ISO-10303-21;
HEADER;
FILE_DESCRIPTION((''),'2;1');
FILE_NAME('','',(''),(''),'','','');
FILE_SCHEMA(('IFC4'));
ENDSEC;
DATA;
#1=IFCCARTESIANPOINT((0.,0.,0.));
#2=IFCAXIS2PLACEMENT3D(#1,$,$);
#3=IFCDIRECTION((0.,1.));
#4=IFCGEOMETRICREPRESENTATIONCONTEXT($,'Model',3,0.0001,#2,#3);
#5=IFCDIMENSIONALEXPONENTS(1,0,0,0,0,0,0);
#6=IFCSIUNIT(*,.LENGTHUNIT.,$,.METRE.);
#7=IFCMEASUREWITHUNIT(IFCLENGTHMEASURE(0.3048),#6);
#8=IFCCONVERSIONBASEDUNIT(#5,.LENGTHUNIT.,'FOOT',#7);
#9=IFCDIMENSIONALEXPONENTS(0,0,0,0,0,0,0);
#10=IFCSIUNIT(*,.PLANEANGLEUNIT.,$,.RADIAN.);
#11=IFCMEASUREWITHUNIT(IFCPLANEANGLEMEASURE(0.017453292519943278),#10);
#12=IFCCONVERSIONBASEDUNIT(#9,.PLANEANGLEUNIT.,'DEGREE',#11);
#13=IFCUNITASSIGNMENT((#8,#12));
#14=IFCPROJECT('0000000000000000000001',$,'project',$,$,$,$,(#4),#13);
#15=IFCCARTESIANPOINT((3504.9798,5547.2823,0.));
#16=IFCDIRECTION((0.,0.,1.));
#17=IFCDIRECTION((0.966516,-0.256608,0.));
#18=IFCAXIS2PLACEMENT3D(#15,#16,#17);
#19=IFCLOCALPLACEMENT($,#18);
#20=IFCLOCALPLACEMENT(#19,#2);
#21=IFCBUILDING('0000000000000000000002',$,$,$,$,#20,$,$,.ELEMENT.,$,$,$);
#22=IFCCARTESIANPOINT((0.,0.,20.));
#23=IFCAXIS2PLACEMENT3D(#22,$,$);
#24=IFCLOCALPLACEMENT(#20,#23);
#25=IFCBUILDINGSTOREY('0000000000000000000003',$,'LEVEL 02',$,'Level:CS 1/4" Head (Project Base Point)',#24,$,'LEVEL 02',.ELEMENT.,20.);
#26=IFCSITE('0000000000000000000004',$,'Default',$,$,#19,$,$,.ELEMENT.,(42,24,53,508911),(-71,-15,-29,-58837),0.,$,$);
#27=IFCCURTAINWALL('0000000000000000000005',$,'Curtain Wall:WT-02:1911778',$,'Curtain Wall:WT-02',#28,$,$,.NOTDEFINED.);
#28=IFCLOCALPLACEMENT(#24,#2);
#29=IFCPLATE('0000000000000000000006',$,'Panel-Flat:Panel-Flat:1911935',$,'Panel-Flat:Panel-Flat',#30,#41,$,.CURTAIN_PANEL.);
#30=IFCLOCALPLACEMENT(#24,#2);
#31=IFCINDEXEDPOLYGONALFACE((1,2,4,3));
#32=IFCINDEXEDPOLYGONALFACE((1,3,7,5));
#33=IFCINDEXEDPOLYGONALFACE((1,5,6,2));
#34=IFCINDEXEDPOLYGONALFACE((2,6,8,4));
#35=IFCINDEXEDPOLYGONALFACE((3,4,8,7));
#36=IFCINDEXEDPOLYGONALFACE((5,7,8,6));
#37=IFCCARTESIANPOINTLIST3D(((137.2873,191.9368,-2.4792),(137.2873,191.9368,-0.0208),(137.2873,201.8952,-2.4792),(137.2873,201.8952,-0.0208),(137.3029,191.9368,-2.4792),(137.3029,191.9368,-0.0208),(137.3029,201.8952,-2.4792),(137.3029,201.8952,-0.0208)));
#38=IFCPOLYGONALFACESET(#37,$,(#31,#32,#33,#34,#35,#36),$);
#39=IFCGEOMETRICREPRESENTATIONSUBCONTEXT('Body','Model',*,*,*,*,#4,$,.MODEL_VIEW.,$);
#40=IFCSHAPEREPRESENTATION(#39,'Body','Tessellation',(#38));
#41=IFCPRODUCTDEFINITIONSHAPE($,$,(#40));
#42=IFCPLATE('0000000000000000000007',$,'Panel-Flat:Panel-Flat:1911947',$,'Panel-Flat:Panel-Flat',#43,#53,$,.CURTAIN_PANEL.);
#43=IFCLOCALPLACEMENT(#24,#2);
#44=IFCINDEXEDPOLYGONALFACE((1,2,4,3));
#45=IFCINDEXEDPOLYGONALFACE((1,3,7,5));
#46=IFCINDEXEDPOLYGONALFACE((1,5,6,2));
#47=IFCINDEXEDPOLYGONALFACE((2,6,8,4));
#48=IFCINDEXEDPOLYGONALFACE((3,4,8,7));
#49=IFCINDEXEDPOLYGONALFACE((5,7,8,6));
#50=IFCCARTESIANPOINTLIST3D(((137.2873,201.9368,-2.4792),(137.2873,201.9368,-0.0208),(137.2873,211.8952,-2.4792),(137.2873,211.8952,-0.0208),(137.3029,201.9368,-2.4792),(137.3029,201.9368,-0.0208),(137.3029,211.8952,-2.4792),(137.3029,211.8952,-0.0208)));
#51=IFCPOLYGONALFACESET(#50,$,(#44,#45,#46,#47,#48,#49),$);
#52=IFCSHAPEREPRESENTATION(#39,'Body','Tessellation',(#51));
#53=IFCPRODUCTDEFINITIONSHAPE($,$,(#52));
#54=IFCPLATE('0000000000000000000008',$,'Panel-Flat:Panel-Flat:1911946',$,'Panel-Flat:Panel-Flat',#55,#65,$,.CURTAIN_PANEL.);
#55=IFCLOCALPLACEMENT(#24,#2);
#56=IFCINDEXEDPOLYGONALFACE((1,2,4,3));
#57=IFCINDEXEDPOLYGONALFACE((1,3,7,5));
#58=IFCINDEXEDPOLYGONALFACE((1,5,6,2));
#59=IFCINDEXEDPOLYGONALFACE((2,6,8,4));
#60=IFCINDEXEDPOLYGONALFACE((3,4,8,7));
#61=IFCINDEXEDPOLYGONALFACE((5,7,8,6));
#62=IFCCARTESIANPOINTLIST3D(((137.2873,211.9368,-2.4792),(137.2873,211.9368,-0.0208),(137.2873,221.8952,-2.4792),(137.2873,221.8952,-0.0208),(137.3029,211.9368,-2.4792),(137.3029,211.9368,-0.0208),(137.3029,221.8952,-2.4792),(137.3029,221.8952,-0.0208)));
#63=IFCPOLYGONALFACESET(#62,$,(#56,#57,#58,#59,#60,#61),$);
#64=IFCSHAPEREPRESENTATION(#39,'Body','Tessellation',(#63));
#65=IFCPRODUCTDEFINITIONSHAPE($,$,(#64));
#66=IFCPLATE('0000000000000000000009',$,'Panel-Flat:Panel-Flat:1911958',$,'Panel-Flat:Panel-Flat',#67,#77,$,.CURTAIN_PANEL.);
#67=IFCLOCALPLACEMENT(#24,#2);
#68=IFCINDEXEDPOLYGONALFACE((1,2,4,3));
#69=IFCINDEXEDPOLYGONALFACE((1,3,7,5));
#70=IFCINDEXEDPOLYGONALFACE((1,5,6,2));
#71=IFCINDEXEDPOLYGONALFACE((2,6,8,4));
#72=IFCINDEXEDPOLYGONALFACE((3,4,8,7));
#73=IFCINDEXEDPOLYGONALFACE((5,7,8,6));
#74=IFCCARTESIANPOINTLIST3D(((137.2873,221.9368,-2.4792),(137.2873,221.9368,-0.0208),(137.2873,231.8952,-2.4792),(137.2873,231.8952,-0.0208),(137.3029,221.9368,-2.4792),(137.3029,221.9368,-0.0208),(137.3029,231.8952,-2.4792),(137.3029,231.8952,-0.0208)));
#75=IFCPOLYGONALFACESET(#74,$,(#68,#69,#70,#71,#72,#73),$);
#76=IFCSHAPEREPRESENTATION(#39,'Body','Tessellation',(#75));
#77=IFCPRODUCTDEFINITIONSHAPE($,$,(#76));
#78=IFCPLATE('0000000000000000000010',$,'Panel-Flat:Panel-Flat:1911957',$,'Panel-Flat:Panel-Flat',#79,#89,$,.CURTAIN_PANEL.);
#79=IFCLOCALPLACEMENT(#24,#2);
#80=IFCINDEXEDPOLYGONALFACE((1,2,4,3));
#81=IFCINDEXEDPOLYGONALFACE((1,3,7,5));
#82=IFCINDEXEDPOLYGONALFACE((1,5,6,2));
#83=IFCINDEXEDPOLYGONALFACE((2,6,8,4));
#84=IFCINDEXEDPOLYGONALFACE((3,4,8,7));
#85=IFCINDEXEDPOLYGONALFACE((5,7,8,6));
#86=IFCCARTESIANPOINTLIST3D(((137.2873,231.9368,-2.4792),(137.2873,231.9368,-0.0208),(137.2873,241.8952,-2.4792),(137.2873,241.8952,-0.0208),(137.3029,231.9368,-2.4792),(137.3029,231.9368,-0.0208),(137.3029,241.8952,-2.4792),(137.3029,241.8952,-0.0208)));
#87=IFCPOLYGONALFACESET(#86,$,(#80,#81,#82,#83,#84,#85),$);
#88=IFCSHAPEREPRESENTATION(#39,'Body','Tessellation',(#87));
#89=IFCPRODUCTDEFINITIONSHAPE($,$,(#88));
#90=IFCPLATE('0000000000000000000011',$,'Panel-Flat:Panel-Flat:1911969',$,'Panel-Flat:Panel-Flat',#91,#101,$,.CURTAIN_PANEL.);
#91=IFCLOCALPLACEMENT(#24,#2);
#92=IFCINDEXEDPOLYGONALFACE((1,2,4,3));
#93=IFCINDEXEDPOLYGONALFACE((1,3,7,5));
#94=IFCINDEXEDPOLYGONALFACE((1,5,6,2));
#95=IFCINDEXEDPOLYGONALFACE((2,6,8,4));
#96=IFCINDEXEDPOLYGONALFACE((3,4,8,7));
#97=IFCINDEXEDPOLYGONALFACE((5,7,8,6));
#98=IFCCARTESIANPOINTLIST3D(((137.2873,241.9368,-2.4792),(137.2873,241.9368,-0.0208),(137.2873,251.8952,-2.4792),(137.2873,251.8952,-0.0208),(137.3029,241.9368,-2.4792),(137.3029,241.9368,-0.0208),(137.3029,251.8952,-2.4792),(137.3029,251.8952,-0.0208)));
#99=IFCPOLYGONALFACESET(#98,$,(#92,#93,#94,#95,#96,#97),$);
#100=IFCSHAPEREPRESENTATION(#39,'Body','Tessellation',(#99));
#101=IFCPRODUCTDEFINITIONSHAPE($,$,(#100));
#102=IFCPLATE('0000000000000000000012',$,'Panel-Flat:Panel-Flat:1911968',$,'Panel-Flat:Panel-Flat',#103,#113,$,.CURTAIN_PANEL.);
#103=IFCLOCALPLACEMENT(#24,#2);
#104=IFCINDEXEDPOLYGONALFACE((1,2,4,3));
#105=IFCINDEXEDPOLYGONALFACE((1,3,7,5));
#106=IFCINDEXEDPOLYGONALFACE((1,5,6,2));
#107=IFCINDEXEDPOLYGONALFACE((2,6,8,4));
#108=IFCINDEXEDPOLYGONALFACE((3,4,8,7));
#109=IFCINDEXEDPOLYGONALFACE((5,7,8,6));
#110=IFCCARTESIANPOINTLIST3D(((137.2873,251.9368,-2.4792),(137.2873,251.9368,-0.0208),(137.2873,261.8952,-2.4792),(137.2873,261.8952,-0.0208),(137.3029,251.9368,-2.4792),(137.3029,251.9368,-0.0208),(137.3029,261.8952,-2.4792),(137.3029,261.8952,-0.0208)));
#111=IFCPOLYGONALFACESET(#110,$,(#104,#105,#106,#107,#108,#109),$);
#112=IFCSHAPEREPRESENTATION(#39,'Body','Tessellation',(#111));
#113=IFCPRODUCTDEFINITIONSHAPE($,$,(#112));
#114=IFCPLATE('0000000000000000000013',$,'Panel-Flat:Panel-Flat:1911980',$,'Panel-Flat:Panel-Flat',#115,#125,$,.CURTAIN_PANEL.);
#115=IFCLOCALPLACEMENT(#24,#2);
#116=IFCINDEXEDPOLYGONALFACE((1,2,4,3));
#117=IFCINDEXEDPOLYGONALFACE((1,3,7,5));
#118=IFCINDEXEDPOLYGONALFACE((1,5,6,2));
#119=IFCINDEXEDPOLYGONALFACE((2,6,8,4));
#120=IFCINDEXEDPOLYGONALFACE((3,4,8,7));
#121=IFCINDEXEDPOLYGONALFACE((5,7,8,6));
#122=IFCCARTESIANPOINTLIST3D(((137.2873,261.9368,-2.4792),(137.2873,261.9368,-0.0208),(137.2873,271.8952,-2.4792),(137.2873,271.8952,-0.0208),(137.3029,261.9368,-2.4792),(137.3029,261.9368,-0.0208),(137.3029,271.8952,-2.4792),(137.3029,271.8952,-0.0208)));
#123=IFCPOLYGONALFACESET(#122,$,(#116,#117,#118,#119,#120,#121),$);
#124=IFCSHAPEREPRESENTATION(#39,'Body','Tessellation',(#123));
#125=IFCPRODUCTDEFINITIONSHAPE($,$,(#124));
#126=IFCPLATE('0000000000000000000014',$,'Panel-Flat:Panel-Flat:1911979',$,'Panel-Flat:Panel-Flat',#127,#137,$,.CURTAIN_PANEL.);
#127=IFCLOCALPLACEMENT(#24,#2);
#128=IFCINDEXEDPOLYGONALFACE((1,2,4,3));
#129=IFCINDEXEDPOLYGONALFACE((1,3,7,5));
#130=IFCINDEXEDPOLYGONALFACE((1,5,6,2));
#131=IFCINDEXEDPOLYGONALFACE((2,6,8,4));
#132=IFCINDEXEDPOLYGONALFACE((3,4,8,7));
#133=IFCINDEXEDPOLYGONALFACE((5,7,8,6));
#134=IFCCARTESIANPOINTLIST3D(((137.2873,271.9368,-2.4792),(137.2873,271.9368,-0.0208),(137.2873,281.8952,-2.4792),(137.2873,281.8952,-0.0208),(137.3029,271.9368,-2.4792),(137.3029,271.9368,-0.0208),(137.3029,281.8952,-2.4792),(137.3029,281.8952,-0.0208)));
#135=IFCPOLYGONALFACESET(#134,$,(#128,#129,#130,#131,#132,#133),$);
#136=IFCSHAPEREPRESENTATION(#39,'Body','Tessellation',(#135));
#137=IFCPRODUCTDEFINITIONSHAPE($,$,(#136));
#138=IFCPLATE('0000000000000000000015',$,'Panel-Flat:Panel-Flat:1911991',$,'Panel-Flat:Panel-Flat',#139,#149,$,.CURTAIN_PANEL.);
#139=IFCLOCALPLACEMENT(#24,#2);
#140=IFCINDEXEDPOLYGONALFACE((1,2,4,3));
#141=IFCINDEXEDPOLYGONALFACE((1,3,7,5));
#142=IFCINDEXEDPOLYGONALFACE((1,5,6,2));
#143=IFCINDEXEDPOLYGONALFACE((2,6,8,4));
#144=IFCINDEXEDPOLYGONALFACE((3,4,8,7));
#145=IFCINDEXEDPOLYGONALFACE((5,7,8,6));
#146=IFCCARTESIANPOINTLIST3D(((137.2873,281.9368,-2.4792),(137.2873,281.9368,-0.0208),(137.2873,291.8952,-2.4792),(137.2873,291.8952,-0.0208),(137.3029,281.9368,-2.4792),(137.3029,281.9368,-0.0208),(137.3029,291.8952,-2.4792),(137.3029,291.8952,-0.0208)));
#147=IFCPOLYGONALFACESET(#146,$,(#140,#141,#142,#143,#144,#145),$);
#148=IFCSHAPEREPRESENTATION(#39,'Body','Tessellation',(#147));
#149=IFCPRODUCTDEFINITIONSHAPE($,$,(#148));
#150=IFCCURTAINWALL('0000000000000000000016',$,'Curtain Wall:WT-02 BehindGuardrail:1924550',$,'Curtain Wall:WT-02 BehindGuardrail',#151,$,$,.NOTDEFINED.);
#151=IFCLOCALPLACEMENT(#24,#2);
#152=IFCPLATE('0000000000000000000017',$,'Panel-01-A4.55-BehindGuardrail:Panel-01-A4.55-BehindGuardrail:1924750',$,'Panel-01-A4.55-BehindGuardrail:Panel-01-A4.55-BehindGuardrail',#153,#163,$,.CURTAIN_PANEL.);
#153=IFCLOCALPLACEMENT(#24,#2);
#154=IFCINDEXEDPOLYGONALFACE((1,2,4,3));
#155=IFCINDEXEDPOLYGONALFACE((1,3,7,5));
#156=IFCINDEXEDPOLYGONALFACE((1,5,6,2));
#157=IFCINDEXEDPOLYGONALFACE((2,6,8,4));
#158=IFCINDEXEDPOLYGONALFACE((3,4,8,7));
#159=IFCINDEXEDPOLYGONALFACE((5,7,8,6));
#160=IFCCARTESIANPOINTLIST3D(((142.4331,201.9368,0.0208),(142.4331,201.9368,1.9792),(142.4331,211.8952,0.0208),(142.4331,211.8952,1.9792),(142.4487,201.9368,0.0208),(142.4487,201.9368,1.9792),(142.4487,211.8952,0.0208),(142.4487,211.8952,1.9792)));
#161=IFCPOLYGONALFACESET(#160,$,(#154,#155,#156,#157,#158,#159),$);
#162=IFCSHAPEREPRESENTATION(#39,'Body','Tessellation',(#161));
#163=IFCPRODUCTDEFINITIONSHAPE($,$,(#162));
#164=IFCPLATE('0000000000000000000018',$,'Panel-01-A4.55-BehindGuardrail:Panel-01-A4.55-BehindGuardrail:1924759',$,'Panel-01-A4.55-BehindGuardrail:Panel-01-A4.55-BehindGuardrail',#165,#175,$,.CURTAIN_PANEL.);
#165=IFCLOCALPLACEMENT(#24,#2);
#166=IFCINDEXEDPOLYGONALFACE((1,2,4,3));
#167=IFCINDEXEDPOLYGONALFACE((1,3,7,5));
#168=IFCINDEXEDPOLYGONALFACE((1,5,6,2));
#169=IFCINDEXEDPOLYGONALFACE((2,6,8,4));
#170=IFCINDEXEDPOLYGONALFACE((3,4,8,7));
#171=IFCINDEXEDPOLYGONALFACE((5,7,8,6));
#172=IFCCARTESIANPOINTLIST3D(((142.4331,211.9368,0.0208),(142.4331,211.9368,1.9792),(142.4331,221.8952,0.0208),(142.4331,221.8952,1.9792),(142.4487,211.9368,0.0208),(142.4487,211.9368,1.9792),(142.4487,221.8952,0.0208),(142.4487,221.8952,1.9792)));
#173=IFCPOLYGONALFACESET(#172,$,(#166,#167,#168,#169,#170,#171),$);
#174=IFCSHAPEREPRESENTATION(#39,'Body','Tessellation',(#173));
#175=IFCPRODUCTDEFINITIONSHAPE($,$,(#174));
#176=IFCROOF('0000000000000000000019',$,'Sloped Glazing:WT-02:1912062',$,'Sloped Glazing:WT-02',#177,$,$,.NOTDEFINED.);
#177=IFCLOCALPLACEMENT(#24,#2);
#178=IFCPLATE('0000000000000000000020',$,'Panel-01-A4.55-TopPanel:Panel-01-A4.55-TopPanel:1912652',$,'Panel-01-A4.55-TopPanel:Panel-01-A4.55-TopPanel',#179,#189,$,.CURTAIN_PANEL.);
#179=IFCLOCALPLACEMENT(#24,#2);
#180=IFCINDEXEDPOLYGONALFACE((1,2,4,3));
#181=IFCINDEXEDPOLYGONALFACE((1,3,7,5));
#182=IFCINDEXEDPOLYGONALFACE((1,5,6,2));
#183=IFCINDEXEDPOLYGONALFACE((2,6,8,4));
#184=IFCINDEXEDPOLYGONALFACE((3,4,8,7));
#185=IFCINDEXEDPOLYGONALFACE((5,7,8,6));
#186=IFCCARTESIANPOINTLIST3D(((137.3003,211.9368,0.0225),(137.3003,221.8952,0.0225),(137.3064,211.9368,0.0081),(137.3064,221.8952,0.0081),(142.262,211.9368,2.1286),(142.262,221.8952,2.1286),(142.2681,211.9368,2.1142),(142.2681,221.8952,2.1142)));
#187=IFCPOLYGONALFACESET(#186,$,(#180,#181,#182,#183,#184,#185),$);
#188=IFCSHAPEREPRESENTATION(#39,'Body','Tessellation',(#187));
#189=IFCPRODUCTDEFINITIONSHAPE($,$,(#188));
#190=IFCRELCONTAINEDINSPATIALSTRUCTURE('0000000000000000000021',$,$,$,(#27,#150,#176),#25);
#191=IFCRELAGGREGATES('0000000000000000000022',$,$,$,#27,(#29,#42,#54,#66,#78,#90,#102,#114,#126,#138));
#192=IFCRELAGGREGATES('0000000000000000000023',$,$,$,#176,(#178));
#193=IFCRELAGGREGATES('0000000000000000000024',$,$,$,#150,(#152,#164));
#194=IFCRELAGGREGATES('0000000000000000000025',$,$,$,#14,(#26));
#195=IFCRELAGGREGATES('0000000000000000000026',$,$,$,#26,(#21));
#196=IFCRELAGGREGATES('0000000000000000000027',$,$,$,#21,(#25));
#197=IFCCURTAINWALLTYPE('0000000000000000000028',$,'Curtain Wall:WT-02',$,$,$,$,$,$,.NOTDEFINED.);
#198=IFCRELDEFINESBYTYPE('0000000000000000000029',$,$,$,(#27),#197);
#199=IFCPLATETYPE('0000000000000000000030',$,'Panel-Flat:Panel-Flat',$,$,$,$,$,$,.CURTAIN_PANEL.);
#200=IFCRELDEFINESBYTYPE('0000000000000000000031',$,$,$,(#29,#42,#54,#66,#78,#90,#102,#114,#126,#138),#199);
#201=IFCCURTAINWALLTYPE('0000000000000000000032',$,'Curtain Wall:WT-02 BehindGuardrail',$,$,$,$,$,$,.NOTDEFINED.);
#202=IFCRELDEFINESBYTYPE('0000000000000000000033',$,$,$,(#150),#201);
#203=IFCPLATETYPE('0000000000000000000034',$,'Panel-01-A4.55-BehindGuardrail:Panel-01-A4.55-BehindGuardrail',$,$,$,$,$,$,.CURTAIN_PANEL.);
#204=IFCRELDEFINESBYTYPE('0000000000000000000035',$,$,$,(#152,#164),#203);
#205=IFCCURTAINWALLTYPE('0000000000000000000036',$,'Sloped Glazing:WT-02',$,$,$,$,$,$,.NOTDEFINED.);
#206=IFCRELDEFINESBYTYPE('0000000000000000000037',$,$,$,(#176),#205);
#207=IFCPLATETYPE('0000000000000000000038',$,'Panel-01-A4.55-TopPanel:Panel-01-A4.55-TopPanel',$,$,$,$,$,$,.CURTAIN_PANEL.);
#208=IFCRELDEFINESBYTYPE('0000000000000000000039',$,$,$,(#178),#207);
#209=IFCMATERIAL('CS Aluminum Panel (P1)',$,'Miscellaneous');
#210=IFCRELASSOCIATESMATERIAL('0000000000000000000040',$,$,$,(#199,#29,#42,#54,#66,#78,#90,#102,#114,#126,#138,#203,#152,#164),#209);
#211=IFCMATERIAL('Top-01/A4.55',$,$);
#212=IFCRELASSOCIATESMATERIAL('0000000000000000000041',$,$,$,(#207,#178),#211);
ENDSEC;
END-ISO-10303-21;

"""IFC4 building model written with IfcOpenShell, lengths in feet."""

from ifc_helpers import new_model, entity, si_unit, converted_unit, direction, frame, origin, place, context, subcontext, project, spatial, indexed_curve, outline, extrude, source, transform, mapped, material, type_object, type_shapes, element, aggregate, save


model = new_model("IFC4")

# Units and contexts
model_context = context("Model", 3, precision=0.0001, world=origin(), true_north=direction((0.0, 1.0)))
body_context = subcontext(model_context, "Body", "Model", "MODEL_VIEW")
ifc_project = project(units=[converted_unit("LENGTHUNIT", "FOOT", entity("IfcLengthMeasure", 0.3048), si_unit("LENGTHUNIT", "METRE"), dimensions=[1, 0, 0, 0, 0, 0, 0]), converted_unit("PLANEANGLEUNIT", "DEGREE", entity("IfcPlaneAngleMeasure", 0.017453292519943278), si_unit("PLANEANGLEUNIT", "RADIAN"), dimensions=[0, 0, 0, 0, 0, 0, 0])], contexts=[model_context])

# Site, building, storey
site_placement = place(None, frame((3504.9798, 5547.2823, 0.0), z_axis=(0.0, 0.0, 1.0), x_axis=(0.966516, -0.256608, 0.0)))
site = spatial("IfcSite", under=ifc_project, at=site_placement, Name="Default", CompositionType="ELEMENT", RefLatitude=(42, 24, 53, 508911), RefLongitude=(-71, -15, -29, -58837), RefElevation=0.0)
building_placement = place(site_placement, origin())
building = spatial("IfcBuilding", under=site, at=building_placement, CompositionType="ELEMENT")
storey_placement = place(building_placement, frame((0.0, 0.0, 20.0)))
storey = spatial("IfcBuildingStorey", under=building, at=storey_placement, Name="LEVEL 02", ObjectType="Level:CS 1/4\" Head (Project Base Point)", LongName="LEVEL 02", CompositionType="ELEMENT", Elevation=20.0)

# Curtain walls, plates
curtain_wall_type_1 = type_object("IfcCurtainWallType", Name="Curtain Wall:WT-02", PredefinedType="NOTDEFINED")
curtain_wall_1_placement = place(storey_placement, frame((0.0, 0.0, -20.0)))
curtain_wall_1 = element("IfcCurtainWall", 1, at=curtain_wall_1_placement, inside=storey, type_object=curtain_wall_type_1, Name="Curtain Wall:WT-02:1911778", ObjectType="Curtain Wall:WT-02", PredefinedType="NOTDEFINED")
ifc_material_1 = material(Name="CS Aluminum Panel (P1)", Category="Miscellaneous")
plate_type_1 = type_object("IfcPlateType", Name="Panel-Flat:Panel-Flat", PredefinedType="CURTAIN_PANEL", material=ifc_material_1)
shared_shape_1 = source(origin(), body_context, "Body", "SweptSolid", [
    extrude(outline(indexed_curve([(-0.0078, -4.9792), (0.0078, -4.9792), (0.0078, 4.9792), (-0.0078, 4.9792), (-0.0078, -4.9792)], self_intersect=False)), frame((4.9792, 0.0078, 0.0), z_axis=(0.0, 0.0, 1.0), x_axis=(0.0, -1.0, 0.0)), (0.0, 0.0, 1.0), 2.4583),
])
type_shapes(plate_type_1, [shared_shape_1])
plate_1_placement = place(curtain_wall_1_placement, frame((137.3029, 191.9368, 17.5208), z_axis=(0.0, 0.0, 1.0), x_axis=(0.0, 1.0, 0.0)))
plate_1 = element("IfcPlate", 2, at=plate_1_placement, type_object=plate_type_1, material=ifc_material_1, Name="Panel-Flat:Panel-Flat:1911935", ObjectType="Panel-Flat:Panel-Flat", PredefinedType="CURTAIN_PANEL", context=body_context, shape_type="MappedRepresentation", body=[
    mapped(shared_shape_1, transform((0.0, 0.0, 0.0), scale=1.0)),
])
plate_2_placement = place(curtain_wall_1_placement, frame((137.3029, 201.9368, 17.5208), z_axis=(0.0, 0.0, 1.0), x_axis=(0.0, 1.0, 0.0)))
plate_2 = element("IfcPlate", 3, at=plate_2_placement, type_object=plate_type_1, material=ifc_material_1, Name="Panel-Flat:Panel-Flat:1911947", ObjectType="Panel-Flat:Panel-Flat", PredefinedType="CURTAIN_PANEL", context=body_context, shape_type="MappedRepresentation", body=[
    mapped(shared_shape_1, transform((0.0, 0.0, 0.0), scale=1.0)),
])
plate_3_placement = place(curtain_wall_1_placement, frame((137.3029, 211.9368, 17.5208), z_axis=(0.0, 0.0, 1.0), x_axis=(0.0, 1.0, 0.0)))
plate_3 = element("IfcPlate", 4, at=plate_3_placement, type_object=plate_type_1, material=ifc_material_1, Name="Panel-Flat:Panel-Flat:1911946", ObjectType="Panel-Flat:Panel-Flat", PredefinedType="CURTAIN_PANEL", context=body_context, shape_type="MappedRepresentation", body=[
    mapped(shared_shape_1, transform((0.0, 0.0, 0.0), scale=1.0)),
])
plate_4_placement = place(curtain_wall_1_placement, frame((137.3029, 221.9368, 17.5208), z_axis=(0.0, 0.0, 1.0), x_axis=(0.0, 1.0, 0.0)))
plate_4 = element("IfcPlate", 5, at=plate_4_placement, type_object=plate_type_1, material=ifc_material_1, Name="Panel-Flat:Panel-Flat:1911958", ObjectType="Panel-Flat:Panel-Flat", PredefinedType="CURTAIN_PANEL", context=body_context, shape_type="MappedRepresentation", body=[
    mapped(shared_shape_1, transform((0.0, 0.0, 0.0), scale=1.0)),
])
plate_5_placement = place(curtain_wall_1_placement, frame((137.3029, 231.9368, 17.5208), z_axis=(0.0, 0.0, 1.0), x_axis=(0.0, 1.0, 0.0)))
plate_5 = element("IfcPlate", 6, at=plate_5_placement, type_object=plate_type_1, material=ifc_material_1, Name="Panel-Flat:Panel-Flat:1911957", ObjectType="Panel-Flat:Panel-Flat", PredefinedType="CURTAIN_PANEL", context=body_context, shape_type="MappedRepresentation", body=[
    mapped(shared_shape_1, transform((0.0, 0.0, 0.0), scale=1.0)),
])
plate_6_placement = place(curtain_wall_1_placement, frame((137.3029, 241.9368, 17.5208), z_axis=(0.0, 0.0, 1.0), x_axis=(0.0, 1.0, 0.0)))
plate_6 = element("IfcPlate", 7, at=plate_6_placement, type_object=plate_type_1, material=ifc_material_1, Name="Panel-Flat:Panel-Flat:1911969", ObjectType="Panel-Flat:Panel-Flat", PredefinedType="CURTAIN_PANEL", context=body_context, shape_type="MappedRepresentation", body=[
    mapped(shared_shape_1, transform((0.0, 0.0, 0.0), scale=1.0)),
])
plate_7_placement = place(curtain_wall_1_placement, frame((137.3029, 251.9368, 17.5208), z_axis=(0.0, 0.0, 1.0), x_axis=(0.0, 1.0, 0.0)))
plate_7 = element("IfcPlate", 8, at=plate_7_placement, type_object=plate_type_1, material=ifc_material_1, Name="Panel-Flat:Panel-Flat:1911968", ObjectType="Panel-Flat:Panel-Flat", PredefinedType="CURTAIN_PANEL", context=body_context, shape_type="MappedRepresentation", body=[
    mapped(shared_shape_1, transform((0.0, 0.0, 0.0), scale=1.0)),
])
plate_8_placement = place(curtain_wall_1_placement, frame((137.3029, 261.9368, 17.5208), z_axis=(0.0, 0.0, 1.0), x_axis=(0.0, 1.0, 0.0)))
plate_8 = element("IfcPlate", 9, at=plate_8_placement, type_object=plate_type_1, material=ifc_material_1, Name="Panel-Flat:Panel-Flat:1911980", ObjectType="Panel-Flat:Panel-Flat", PredefinedType="CURTAIN_PANEL", context=body_context, shape_type="MappedRepresentation", body=[
    mapped(shared_shape_1, transform((0.0, 0.0, 0.0), scale=1.0)),
])
plate_9_placement = place(curtain_wall_1_placement, frame((137.3029, 271.9368, 17.5208), z_axis=(0.0, 0.0, 1.0), x_axis=(0.0, 1.0, 0.0)))
plate_9 = element("IfcPlate", 10, at=plate_9_placement, type_object=plate_type_1, material=ifc_material_1, Name="Panel-Flat:Panel-Flat:1911979", ObjectType="Panel-Flat:Panel-Flat", PredefinedType="CURTAIN_PANEL", context=body_context, shape_type="MappedRepresentation", body=[
    mapped(shared_shape_1, transform((0.0, 0.0, 0.0), scale=1.0)),
])
plate_10_placement = place(curtain_wall_1_placement, frame((137.3029, 281.9368, 17.5208), z_axis=(0.0, 0.0, 1.0), x_axis=(0.0, 1.0, 0.0)))
plate_10 = element("IfcPlate", 11, at=plate_10_placement, type_object=plate_type_1, material=ifc_material_1, Name="Panel-Flat:Panel-Flat:1911991", ObjectType="Panel-Flat:Panel-Flat", PredefinedType="CURTAIN_PANEL", context=body_context, shape_type="MappedRepresentation", body=[
    mapped(shared_shape_1, transform((0.0, 0.0, 0.0), scale=1.0)),
])
aggregate(curtain_wall_1, [plate_1, plate_2, plate_3, plate_4, plate_5, plate_6, plate_7, plate_8, plate_9, plate_10])
curtain_wall_type_2 = type_object("IfcCurtainWallType", Name="Curtain Wall:WT-02 BehindGuardrail", PredefinedType="NOTDEFINED")
curtain_wall_2_placement = place(storey_placement, frame((0.0, 0.0, -20.0)))
curtain_wall_2 = element("IfcCurtainWall", 12, at=curtain_wall_2_placement, inside=storey, type_object=curtain_wall_type_2, Name="Curtain Wall:WT-02 BehindGuardrail:1924550", ObjectType="Curtain Wall:WT-02 BehindGuardrail", PredefinedType="NOTDEFINED")
plate_type_2 = type_object("IfcPlateType", Name="Panel-01-A4.55-BehindGuardrail:Panel-01-A4.55-BehindGuardrail", PredefinedType="CURTAIN_PANEL", material=ifc_material_1)
shared_shape_2 = source(origin(), body_context, "Body", "SweptSolid", [
    extrude(outline(indexed_curve([(-0.0078, -4.9792), (0.0078, -4.9792), (0.0078, 4.9792), (-0.0078, 4.9792), (-0.0078, -4.9792)], self_intersect=False)), frame((4.9792, 0.0078, 0.0), z_axis=(0.0, 0.0, 1.0), x_axis=(0.0, -1.0, 0.0)), (0.0, 0.0, 1.0), 1.9583),
])
type_shapes(plate_type_2, [shared_shape_2])
plate_11_placement = place(curtain_wall_2_placement, frame((142.4487, 201.9368, 20.0208), z_axis=(0.0, 0.0, 1.0), x_axis=(0.0, 1.0, 0.0)))
plate_11 = element("IfcPlate", 13, at=plate_11_placement, type_object=plate_type_2, material=ifc_material_1, Name="Panel-01-A4.55-BehindGuardrail:Panel-01-A4.55-BehindGuardrail:1924750", ObjectType="Panel-01-A4.55-BehindGuardrail:Panel-01-A4.55-BehindGuardrail", PredefinedType="CURTAIN_PANEL", context=body_context, shape_type="MappedRepresentation", body=[
    mapped(shared_shape_2, transform((0.0, 0.0, 0.0), scale=1.0)),
])
plate_12_placement = place(curtain_wall_2_placement, frame((142.4487, 211.9368, 20.0208), z_axis=(0.0, 0.0, 1.0), x_axis=(0.0, 1.0, 0.0)))
plate_12 = element("IfcPlate", 14, at=plate_12_placement, type_object=plate_type_2, material=ifc_material_1, Name="Panel-01-A4.55-BehindGuardrail:Panel-01-A4.55-BehindGuardrail:1924759", ObjectType="Panel-01-A4.55-BehindGuardrail:Panel-01-A4.55-BehindGuardrail", PredefinedType="CURTAIN_PANEL", context=body_context, shape_type="MappedRepresentation", body=[
    mapped(shared_shape_2, transform((0.0, 0.0, 0.0), scale=1.0)),
])

# Roof, plate
curtain_wall_type_3 = type_object("IfcCurtainWallType", Name="Sloped Glazing:WT-02", PredefinedType="NOTDEFINED")
roof_1_placement = place(storey_placement, frame((0.0, 0.0, -20.0)))
roof_1 = element("IfcRoof", 15, at=roof_1_placement, inside=storey, type_object=curtain_wall_type_3, Name="Sloped Glazing:WT-02:1912062", ObjectType="Sloped Glazing:WT-02", PredefinedType="NOTDEFINED")
ifc_material_2 = material(Name="Top-01/A4.55")
plate_type_3 = type_object("IfcPlateType", Name="Panel-01-A4.55-TopPanel:Panel-01-A4.55-TopPanel", PredefinedType="CURTAIN_PANEL", material=ifc_material_2)
shared_shape_3 = source(origin(), body_context, "Body", "SweptSolid", [
    extrude(outline(indexed_curve([(-0.0078, -4.9792), (0.0078, -4.9792), (0.0078, 4.9792), (-0.0078, 4.9792), (-0.0078, -4.9792)], self_intersect=False)), frame((4.9792, 0.0078, 0.0), z_axis=(0.0, 0.0, 1.0), x_axis=(0.0, -1.0, 0.0)), (0.0, 0.0, 1.0), 5.3901),
])
type_shapes(plate_type_3, [shared_shape_3])
plate_13_placement = place(roof_1_placement, frame((137.3003, 221.8952, 20.0225), z_axis=(0.920505, 0.0, 0.390731), x_axis=(0.0, -1.0, 0.0)))
plate_13 = element("IfcPlate", 16, at=plate_13_placement, type_object=plate_type_3, material=ifc_material_2, Name="Panel-01-A4.55-TopPanel:Panel-01-A4.55-TopPanel:1912652", ObjectType="Panel-01-A4.55-TopPanel:Panel-01-A4.55-TopPanel", PredefinedType="CURTAIN_PANEL", context=body_context, shape_type="MappedRepresentation", body=[
    mapped(shared_shape_3, transform((0.0, 0.0, 0.0), scale=1.0)),
])
aggregate(roof_1, [plate_13])

aggregate(curtain_wall_2, [plate_11, plate_12])

save(model, "model.ifc")
